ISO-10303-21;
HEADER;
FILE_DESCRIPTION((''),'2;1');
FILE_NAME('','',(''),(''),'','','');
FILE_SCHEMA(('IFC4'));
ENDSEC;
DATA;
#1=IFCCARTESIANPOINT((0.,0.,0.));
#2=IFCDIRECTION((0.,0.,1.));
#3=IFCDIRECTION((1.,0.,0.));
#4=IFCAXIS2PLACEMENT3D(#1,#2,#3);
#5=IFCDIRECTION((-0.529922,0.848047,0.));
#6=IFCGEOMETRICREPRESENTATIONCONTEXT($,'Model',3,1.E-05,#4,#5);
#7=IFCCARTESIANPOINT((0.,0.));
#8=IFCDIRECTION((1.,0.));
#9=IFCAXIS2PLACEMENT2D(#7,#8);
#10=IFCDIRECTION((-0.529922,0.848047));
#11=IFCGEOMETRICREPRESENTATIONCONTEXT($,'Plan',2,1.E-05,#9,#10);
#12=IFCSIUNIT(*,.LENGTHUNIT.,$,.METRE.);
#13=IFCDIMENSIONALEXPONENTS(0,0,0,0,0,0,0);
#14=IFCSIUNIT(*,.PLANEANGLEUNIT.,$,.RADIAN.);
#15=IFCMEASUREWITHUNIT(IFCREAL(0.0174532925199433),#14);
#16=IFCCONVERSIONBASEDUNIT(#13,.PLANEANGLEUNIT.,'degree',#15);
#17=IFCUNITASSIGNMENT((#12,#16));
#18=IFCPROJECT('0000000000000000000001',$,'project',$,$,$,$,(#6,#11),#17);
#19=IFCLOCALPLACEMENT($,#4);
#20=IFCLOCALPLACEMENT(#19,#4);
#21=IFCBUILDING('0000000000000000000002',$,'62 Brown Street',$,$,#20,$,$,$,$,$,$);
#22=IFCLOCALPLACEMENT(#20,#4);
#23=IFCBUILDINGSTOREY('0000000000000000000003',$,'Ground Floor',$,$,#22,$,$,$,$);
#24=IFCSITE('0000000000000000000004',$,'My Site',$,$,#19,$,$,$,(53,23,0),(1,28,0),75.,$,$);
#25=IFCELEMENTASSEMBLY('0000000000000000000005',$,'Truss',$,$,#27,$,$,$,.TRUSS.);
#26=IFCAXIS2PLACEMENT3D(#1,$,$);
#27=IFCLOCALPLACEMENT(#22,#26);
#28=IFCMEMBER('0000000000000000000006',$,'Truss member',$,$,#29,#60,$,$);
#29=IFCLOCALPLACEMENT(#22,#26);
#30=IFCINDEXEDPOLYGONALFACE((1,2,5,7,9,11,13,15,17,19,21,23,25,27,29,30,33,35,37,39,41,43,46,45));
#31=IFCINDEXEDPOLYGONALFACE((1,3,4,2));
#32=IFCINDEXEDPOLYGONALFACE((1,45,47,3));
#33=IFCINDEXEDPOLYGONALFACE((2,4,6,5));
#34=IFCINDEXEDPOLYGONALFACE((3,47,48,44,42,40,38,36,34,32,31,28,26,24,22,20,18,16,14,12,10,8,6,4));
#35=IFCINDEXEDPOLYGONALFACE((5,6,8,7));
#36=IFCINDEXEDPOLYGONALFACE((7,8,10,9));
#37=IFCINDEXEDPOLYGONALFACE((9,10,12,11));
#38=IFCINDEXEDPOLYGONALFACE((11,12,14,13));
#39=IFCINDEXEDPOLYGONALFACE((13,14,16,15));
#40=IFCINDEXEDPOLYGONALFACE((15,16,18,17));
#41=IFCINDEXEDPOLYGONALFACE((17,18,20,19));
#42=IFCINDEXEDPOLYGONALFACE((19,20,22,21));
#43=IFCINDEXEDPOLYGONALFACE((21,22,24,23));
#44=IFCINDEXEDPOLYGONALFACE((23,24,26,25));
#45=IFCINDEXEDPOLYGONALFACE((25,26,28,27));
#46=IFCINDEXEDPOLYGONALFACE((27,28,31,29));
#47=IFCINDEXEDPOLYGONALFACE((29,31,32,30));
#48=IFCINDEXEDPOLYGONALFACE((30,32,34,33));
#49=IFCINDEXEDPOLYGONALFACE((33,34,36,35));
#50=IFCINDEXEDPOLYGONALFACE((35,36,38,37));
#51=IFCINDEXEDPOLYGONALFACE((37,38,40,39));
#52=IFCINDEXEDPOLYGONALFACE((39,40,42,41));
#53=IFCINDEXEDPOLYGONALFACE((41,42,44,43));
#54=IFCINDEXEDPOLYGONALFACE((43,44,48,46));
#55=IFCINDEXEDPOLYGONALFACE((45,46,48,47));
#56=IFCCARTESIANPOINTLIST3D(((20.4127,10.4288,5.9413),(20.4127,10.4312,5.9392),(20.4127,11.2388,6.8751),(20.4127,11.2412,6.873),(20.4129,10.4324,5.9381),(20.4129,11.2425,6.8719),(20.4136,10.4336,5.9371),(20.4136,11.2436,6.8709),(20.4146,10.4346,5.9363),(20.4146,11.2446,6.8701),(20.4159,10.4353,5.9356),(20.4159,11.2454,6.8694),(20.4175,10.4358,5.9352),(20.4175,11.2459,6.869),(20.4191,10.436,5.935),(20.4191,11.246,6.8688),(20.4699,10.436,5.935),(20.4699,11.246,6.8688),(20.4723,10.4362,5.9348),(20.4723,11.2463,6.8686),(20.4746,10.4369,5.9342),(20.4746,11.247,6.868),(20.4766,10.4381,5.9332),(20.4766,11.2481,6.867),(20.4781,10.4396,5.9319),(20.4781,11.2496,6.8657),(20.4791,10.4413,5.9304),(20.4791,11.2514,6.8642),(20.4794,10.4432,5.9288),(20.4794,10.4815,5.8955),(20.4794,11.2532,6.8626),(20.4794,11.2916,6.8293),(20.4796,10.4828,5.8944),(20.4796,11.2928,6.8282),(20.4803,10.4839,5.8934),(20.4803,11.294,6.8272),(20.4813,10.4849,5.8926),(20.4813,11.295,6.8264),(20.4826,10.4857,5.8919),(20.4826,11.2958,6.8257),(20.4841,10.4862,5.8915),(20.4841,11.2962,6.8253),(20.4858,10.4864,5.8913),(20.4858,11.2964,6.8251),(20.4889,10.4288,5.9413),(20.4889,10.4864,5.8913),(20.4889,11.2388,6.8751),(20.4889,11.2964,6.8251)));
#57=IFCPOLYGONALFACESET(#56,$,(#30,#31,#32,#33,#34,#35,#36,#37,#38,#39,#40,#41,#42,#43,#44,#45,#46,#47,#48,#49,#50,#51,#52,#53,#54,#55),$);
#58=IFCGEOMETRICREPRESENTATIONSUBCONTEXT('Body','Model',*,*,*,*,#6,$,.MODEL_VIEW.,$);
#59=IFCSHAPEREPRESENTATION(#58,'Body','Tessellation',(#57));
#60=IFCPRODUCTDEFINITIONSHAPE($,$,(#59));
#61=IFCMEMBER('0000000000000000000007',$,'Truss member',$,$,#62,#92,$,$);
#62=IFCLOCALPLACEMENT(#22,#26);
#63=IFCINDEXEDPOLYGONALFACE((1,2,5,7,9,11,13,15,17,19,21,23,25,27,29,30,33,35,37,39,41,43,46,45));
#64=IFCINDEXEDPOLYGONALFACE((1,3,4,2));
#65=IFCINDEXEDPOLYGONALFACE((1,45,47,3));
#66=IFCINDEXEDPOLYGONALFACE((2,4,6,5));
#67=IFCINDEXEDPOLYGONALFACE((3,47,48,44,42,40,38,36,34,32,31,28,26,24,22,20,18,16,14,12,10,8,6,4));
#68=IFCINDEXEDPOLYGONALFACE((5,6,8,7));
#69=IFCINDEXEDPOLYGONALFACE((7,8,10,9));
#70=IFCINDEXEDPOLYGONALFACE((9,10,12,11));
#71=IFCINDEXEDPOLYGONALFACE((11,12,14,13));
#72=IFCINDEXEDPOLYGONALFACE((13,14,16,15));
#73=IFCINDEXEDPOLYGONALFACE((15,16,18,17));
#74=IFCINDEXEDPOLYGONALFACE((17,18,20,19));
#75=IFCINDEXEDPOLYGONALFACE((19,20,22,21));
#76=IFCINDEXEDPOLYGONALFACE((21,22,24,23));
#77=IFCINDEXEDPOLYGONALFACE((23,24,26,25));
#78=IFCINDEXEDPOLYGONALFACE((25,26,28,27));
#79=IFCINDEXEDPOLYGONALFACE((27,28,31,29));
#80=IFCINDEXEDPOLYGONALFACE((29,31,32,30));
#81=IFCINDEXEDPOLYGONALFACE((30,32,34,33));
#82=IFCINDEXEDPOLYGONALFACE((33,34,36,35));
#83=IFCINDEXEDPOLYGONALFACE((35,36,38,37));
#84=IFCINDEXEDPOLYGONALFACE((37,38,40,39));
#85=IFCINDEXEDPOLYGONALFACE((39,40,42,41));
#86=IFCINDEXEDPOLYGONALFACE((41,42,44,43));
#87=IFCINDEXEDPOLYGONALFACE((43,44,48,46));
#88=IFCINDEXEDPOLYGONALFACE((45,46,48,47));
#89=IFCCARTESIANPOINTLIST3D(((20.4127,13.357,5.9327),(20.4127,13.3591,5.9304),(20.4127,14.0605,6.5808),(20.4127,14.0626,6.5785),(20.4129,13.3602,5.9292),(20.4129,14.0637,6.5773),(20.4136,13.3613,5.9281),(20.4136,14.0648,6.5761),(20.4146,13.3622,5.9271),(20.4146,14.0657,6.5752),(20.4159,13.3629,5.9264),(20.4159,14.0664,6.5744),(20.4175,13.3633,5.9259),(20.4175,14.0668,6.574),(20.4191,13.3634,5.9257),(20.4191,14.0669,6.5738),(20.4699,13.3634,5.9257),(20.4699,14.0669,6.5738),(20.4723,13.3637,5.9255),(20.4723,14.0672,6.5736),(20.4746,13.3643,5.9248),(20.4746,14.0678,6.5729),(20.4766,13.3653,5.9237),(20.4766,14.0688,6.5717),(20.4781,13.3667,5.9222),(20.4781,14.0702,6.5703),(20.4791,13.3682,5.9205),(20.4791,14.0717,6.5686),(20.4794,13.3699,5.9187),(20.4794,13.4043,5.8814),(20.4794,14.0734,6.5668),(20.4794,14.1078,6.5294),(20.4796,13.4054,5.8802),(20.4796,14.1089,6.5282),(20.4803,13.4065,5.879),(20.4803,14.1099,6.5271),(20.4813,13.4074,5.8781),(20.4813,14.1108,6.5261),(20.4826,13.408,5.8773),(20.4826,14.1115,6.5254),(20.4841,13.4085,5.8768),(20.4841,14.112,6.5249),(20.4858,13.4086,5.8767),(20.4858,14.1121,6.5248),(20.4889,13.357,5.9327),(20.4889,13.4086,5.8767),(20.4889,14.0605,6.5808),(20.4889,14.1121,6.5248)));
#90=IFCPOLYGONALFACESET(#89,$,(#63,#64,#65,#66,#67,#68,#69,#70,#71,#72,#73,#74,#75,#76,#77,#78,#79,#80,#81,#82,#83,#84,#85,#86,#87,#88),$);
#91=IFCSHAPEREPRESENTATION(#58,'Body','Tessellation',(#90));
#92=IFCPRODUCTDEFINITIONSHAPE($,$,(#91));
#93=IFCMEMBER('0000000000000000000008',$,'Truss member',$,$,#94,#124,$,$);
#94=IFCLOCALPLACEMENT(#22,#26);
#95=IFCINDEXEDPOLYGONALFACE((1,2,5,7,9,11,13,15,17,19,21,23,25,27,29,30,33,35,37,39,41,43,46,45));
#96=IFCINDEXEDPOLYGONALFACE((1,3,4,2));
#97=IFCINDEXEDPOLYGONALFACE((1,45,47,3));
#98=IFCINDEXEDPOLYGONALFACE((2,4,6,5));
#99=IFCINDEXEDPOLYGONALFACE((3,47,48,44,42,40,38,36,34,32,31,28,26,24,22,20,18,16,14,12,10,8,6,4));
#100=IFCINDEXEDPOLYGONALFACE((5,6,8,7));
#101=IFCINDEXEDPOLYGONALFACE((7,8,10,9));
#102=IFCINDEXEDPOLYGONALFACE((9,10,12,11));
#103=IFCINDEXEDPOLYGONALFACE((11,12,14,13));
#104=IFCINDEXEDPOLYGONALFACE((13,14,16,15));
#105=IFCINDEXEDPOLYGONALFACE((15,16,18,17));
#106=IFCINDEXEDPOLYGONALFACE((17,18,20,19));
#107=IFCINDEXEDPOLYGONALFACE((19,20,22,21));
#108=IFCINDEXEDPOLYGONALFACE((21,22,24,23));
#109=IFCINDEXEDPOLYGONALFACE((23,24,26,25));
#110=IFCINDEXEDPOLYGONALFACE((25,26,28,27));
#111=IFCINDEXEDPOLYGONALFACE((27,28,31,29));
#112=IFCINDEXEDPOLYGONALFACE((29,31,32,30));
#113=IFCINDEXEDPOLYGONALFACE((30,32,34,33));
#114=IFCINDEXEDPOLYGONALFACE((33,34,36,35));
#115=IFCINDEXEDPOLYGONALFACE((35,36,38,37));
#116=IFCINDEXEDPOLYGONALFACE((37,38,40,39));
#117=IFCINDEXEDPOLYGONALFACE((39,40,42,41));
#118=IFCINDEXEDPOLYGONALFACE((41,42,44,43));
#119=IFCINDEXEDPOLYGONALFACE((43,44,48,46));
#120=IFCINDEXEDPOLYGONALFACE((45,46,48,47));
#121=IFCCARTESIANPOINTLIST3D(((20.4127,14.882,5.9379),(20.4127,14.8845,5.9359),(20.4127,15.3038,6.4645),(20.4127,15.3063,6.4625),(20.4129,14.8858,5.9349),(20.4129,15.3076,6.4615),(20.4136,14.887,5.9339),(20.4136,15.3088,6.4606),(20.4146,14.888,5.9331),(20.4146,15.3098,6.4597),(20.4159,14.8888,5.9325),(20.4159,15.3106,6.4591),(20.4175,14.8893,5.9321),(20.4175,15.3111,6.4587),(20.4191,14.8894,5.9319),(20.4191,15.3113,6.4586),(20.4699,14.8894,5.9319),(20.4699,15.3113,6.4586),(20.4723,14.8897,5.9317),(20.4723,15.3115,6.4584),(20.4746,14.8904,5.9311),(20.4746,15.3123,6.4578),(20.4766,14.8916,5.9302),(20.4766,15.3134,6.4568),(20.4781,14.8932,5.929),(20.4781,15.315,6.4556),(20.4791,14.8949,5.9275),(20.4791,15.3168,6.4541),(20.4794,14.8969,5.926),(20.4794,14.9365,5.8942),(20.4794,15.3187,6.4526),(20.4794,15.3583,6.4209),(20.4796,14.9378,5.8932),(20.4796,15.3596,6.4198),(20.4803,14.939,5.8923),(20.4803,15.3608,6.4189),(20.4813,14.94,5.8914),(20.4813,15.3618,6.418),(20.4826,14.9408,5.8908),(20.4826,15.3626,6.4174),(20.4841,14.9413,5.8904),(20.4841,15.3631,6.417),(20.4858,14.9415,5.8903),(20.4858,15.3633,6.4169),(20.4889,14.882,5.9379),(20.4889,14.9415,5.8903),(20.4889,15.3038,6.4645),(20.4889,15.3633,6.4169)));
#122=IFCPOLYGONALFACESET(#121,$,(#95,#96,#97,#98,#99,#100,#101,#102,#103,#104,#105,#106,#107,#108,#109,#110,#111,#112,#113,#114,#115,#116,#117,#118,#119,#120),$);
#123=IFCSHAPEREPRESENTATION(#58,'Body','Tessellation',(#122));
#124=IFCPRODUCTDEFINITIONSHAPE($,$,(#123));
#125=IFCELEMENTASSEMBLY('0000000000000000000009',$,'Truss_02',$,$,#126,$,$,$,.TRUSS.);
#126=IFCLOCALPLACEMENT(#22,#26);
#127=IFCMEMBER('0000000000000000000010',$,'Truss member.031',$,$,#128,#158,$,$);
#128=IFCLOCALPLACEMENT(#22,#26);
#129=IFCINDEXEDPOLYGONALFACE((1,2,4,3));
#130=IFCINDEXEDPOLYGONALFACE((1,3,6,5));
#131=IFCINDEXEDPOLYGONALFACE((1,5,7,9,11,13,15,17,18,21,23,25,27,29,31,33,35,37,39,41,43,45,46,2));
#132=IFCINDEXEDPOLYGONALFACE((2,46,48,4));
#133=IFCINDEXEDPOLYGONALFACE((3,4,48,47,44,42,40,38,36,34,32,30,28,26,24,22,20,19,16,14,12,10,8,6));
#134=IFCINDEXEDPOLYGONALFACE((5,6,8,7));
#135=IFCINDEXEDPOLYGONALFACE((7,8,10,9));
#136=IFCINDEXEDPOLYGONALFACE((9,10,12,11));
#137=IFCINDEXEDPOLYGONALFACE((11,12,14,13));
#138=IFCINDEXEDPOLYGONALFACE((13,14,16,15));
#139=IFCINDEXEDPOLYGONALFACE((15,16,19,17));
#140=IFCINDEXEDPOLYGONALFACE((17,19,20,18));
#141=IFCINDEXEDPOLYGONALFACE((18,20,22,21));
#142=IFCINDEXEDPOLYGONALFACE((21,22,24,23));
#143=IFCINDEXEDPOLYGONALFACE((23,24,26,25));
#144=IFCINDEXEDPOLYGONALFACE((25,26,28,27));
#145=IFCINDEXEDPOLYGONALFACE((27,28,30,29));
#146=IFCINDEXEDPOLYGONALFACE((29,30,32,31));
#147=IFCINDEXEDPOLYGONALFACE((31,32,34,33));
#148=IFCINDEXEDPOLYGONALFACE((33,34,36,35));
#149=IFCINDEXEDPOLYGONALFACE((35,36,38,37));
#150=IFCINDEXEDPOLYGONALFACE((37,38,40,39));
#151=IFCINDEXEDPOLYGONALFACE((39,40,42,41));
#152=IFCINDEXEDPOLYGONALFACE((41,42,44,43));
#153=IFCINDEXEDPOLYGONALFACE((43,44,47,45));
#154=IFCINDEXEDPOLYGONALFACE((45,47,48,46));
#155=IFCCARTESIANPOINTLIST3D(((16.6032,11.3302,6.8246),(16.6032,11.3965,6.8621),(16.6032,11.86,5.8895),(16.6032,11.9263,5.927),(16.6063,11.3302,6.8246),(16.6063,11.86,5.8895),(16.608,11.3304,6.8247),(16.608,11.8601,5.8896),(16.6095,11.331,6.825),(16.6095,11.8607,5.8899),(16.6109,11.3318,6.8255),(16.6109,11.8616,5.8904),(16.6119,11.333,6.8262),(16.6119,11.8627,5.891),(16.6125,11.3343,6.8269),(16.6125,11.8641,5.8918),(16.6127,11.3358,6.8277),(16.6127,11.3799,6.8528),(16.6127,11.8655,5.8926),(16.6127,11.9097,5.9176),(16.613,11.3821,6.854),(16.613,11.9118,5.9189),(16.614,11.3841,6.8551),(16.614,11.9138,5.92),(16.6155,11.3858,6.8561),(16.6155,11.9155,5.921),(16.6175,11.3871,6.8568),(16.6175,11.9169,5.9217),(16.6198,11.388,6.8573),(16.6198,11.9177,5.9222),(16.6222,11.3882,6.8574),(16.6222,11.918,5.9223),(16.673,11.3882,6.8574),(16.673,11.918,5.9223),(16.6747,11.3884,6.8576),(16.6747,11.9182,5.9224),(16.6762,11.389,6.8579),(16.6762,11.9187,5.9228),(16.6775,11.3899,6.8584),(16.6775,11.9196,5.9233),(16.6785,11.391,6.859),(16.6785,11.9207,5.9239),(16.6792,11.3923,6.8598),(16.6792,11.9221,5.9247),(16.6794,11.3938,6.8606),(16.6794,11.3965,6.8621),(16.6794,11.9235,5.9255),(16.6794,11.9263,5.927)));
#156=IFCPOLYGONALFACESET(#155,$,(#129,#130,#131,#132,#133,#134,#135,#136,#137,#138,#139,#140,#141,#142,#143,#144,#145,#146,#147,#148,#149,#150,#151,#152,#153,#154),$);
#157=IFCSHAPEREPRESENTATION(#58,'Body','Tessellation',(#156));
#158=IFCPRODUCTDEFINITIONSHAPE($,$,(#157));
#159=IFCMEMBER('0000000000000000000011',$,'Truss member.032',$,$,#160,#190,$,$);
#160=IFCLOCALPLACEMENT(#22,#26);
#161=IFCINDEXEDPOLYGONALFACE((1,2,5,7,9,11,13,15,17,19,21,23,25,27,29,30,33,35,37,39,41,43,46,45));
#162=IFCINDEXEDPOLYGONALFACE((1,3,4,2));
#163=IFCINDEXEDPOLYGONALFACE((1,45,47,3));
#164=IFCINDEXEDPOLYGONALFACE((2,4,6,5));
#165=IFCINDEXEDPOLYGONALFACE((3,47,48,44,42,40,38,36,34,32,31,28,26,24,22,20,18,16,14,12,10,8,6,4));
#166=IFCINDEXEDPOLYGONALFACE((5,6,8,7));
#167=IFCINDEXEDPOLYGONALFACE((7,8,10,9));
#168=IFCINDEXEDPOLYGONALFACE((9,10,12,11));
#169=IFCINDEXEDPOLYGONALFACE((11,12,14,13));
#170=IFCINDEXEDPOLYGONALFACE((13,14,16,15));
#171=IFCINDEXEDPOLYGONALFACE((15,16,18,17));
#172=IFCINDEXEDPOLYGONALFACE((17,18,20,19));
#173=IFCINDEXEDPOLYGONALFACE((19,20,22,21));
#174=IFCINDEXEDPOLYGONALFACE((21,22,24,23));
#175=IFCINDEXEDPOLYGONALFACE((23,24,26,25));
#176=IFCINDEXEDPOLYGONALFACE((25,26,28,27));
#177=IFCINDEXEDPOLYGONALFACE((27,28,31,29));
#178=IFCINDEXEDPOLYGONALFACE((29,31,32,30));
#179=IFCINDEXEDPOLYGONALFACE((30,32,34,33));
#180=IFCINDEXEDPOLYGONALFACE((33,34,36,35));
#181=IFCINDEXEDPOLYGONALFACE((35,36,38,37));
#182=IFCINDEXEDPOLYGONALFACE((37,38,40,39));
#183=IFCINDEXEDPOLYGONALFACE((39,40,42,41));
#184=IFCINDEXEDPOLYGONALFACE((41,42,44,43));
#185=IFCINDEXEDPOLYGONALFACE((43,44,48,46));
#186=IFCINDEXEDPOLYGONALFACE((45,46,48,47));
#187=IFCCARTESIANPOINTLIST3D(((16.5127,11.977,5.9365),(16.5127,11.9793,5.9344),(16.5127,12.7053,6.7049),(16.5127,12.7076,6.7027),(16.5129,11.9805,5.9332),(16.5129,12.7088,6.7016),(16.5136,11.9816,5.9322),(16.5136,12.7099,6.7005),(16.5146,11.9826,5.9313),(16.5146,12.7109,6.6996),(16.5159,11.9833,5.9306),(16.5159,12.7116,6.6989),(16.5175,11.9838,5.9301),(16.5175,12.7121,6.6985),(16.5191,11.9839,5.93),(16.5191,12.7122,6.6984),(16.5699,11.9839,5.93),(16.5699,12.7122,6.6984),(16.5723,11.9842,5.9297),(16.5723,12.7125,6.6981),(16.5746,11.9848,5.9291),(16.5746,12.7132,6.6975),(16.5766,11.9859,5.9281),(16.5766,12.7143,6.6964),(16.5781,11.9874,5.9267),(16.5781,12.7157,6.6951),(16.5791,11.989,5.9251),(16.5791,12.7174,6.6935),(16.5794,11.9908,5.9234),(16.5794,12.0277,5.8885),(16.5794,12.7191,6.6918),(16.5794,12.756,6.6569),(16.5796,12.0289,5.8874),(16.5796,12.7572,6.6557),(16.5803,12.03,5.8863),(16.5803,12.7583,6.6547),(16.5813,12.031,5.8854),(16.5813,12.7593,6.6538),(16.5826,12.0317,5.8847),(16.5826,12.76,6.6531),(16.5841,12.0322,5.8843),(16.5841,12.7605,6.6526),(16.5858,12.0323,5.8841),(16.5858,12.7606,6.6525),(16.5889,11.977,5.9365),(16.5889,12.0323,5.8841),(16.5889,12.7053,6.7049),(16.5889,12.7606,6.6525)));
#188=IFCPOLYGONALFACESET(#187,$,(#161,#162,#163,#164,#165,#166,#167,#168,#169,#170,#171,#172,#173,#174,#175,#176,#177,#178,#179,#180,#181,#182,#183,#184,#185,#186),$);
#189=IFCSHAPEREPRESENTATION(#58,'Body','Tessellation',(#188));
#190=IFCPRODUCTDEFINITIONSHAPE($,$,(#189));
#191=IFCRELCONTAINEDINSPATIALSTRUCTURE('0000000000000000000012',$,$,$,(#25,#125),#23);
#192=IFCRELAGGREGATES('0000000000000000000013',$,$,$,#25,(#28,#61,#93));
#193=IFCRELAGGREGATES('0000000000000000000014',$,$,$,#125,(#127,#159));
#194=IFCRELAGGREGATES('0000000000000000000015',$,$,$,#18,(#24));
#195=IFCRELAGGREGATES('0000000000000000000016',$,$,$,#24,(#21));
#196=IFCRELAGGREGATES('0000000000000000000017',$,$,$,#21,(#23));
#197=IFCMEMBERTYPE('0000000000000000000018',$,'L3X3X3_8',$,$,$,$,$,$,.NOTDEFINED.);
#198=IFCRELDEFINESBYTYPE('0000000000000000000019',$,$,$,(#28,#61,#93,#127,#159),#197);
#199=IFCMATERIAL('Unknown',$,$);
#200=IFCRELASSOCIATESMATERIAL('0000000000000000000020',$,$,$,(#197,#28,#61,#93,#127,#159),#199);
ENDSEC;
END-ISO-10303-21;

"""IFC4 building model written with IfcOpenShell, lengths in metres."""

from ifc_helpers import new_model, entity, si_unit, converted_unit, direction, frame, origin_with_axes, origin_2d_with_axis, place, context, subcontext, project, spatial, l_section, extrude, material, material_profile, profile_set, profile_usage, type_object, element, aggregate, save


model = new_model("IFC4")

# Units and contexts
model_context = context("Model", 3, precision=1e-05, world=origin_with_axes(), true_north=direction((-0.529922, 0.848047, 0.0)))
plan_context = context("Plan", 2, precision=1e-05, world=origin_2d_with_axis(), true_north=direction((-0.529922, 0.848047)))
body_context = subcontext(model_context, "Body", "Model", "MODEL_VIEW")
ifc_project = project(units=[si_unit("LENGTHUNIT", "METRE"), converted_unit("PLANEANGLEUNIT", "degree", entity("IfcReal", 0.0174532925199433), si_unit("PLANEANGLEUNIT", "RADIAN"), dimensions=[0, 0, 0, 0, 0, 0, 0])], contexts=[model_context, plan_context])

# Site, building, storey
site_placement = place(None, origin_with_axes())
site = spatial("IfcSite", under=ifc_project, at=site_placement, Name="My Site", RefLatitude=(53, 23, 0), RefLongitude=(1, 28, 0), RefElevation=75.0)
building_placement = place(site_placement, origin_with_axes())
building = spatial("IfcBuilding", under=site, at=building_placement, Name="62 Brown Street")
storey_placement = place(building_placement, origin_with_axes())
storey = spatial("IfcBuildingStorey", under=building, at=storey_placement, Name="Ground Floor")

# Element assemblies, members
assembly_1_placement = place(storey_placement, frame((20.5032, 10.4288, 6.9738), z_axis=(0.0, 0.0, 1.0), x_axis=(1.0, 0.0, 0.0)))
assembly_1 = element("IfcElementAssembly", 1, at=assembly_1_placement, inside=storey, Name="Truss", PredefinedType="TRUSS")
ifc_material_1 = material(Name="Unknown")
ifc_material_profile_1 = material_profile(ifc_material_1, l_section(Depth=0.0762, Width=0.0762, Thickness=0.0095, FilletRadius=0.0095, EdgeRadius=0.0064))
ifc_profile_set_1 = profile_set([ifc_material_profile_1])
ifc_profile_usage_1 = profile_usage(ifc_profile_set_1, cardinal=5)
member_type_1 = type_object("IfcMemberType", Name="L3X3X3_8", PredefinedType="NOTDEFINED", material=ifc_profile_set_1)
member_1_placement = place(assembly_1_placement, frame((-0.0524, 0.8388, -0.1236), z_axis=(0.000001, -0.655276, -0.755389), x_axis=(-1.0, -0.000001, 0.0)))
member_1 = element("IfcMember", 2, at=member_1_placement, type_object=member_type_1, material=ifc_profile_usage_1, Name="Truss member", context=body_context, shape_type="SweptSolid", body=[
    extrude(l_section(Depth=0.0762, Width=0.0762, Thickness=0.0095, FilletRadius=0.0095, EdgeRadius=0.0064), origin_with_axes(), (0.0, 0.0, 1.0), 1.2362),
])
ifc_profile_usage_2 = profile_usage(ifc_profile_set_1, cardinal=5)
member_2_placement = place(assembly_1_placement, frame((-0.0524, 3.6575, -0.421), z_axis=(0.000001, -0.735484, -0.677542), x_axis=(-1.0, -0.000001, 0.0)))
member_2 = element("IfcMember", 3, at=member_2_placement, type_object=member_type_1, material=ifc_profile_usage_2, Name="Truss member", context=body_context, shape_type="SweptSolid", body=[
    extrude(l_section(Depth=0.0762, Width=0.0762, Thickness=0.0095, FilletRadius=0.0095, EdgeRadius=0.0064), origin_with_axes(), (0.0, 0.0, 1.0), 0.9565),
])
ifc_profile_usage_3 = profile_usage(ifc_profile_set_1, cardinal=5)
member_3_placement = place(assembly_1_placement, frame((-0.0524, 4.9048, -0.5331), z_axis=(0.000001, -0.625169, -0.780489), x_axis=(-1.0, -0.000001, 0.0)))
member_3 = element("IfcMember", 4, at=member_3_placement, type_object=member_type_1, material=ifc_profile_usage_3, Name="Truss member", context=body_context, shape_type="SweptSolid", body=[
    extrude(l_section(Depth=0.0762, Width=0.0762, Thickness=0.0095, FilletRadius=0.0095, EdgeRadius=0.0064), origin_with_axes(), (0.0, 0.0, 1.0), 0.6747),
])
aggregate(assembly_1, [member_1, member_2, member_3])
assembly_2_placement = place(storey_placement, frame((16.6032, 10.4288, 6.9738), z_axis=(0.0, 0.0, 1.0), x_axis=(1.0, 0.0, 0.0)))
assembly_2 = element("IfcElementAssembly", 5, at=assembly_2_placement, inside=storey, Name="Truss_02", PredefinedType="TRUSS")
ifc_profile_usage_4 = profile_usage(ifc_profile_set_1, cardinal=5)
member_4_placement = place(assembly_2_placement, frame((0.0381, 0.9346, -0.1304), z_axis=(0.0, 0.492899, -0.870086), x_axis=(1.0, 0.0, 0.0)))
member_4 = element("IfcMember", 6, at=member_4_placement, type_object=member_type_1, material=ifc_profile_usage_4, Name="Truss member.031", context=body_context, shape_type="SweptSolid", body=[
    extrude(l_section(Depth=0.0762, Width=0.0762, Thickness=0.0095, FilletRadius=0.0095, EdgeRadius=0.0064), origin_with_axes(), (0.0, 0.0, 1.0), 1.0747),
])
ifc_profile_usage_5 = profile_usage(ifc_profile_set_1, cardinal=5)
member_5_placement = place(assembly_2_placement, frame((-0.0524, 2.3042, -0.2951), z_axis=(0.000001, -0.687927, -0.72578), x_axis=(-1.0, 0.0, 0.0)))
member_5 = element("IfcMember", 7, at=member_5_placement, type_object=member_type_1, material=ifc_profile_usage_5, Name="Truss member.032", context=body_context, shape_type="SweptSolid", body=[
    extrude(l_section(Depth=0.0762, Width=0.0762, Thickness=0.0095, FilletRadius=0.0095, EdgeRadius=0.0064), origin_with_axes(), (0.0, 0.0, 1.0), 1.0587),
])

aggregate(assembly_2, [member_4, member_5])

save(model, "model.ifc")
